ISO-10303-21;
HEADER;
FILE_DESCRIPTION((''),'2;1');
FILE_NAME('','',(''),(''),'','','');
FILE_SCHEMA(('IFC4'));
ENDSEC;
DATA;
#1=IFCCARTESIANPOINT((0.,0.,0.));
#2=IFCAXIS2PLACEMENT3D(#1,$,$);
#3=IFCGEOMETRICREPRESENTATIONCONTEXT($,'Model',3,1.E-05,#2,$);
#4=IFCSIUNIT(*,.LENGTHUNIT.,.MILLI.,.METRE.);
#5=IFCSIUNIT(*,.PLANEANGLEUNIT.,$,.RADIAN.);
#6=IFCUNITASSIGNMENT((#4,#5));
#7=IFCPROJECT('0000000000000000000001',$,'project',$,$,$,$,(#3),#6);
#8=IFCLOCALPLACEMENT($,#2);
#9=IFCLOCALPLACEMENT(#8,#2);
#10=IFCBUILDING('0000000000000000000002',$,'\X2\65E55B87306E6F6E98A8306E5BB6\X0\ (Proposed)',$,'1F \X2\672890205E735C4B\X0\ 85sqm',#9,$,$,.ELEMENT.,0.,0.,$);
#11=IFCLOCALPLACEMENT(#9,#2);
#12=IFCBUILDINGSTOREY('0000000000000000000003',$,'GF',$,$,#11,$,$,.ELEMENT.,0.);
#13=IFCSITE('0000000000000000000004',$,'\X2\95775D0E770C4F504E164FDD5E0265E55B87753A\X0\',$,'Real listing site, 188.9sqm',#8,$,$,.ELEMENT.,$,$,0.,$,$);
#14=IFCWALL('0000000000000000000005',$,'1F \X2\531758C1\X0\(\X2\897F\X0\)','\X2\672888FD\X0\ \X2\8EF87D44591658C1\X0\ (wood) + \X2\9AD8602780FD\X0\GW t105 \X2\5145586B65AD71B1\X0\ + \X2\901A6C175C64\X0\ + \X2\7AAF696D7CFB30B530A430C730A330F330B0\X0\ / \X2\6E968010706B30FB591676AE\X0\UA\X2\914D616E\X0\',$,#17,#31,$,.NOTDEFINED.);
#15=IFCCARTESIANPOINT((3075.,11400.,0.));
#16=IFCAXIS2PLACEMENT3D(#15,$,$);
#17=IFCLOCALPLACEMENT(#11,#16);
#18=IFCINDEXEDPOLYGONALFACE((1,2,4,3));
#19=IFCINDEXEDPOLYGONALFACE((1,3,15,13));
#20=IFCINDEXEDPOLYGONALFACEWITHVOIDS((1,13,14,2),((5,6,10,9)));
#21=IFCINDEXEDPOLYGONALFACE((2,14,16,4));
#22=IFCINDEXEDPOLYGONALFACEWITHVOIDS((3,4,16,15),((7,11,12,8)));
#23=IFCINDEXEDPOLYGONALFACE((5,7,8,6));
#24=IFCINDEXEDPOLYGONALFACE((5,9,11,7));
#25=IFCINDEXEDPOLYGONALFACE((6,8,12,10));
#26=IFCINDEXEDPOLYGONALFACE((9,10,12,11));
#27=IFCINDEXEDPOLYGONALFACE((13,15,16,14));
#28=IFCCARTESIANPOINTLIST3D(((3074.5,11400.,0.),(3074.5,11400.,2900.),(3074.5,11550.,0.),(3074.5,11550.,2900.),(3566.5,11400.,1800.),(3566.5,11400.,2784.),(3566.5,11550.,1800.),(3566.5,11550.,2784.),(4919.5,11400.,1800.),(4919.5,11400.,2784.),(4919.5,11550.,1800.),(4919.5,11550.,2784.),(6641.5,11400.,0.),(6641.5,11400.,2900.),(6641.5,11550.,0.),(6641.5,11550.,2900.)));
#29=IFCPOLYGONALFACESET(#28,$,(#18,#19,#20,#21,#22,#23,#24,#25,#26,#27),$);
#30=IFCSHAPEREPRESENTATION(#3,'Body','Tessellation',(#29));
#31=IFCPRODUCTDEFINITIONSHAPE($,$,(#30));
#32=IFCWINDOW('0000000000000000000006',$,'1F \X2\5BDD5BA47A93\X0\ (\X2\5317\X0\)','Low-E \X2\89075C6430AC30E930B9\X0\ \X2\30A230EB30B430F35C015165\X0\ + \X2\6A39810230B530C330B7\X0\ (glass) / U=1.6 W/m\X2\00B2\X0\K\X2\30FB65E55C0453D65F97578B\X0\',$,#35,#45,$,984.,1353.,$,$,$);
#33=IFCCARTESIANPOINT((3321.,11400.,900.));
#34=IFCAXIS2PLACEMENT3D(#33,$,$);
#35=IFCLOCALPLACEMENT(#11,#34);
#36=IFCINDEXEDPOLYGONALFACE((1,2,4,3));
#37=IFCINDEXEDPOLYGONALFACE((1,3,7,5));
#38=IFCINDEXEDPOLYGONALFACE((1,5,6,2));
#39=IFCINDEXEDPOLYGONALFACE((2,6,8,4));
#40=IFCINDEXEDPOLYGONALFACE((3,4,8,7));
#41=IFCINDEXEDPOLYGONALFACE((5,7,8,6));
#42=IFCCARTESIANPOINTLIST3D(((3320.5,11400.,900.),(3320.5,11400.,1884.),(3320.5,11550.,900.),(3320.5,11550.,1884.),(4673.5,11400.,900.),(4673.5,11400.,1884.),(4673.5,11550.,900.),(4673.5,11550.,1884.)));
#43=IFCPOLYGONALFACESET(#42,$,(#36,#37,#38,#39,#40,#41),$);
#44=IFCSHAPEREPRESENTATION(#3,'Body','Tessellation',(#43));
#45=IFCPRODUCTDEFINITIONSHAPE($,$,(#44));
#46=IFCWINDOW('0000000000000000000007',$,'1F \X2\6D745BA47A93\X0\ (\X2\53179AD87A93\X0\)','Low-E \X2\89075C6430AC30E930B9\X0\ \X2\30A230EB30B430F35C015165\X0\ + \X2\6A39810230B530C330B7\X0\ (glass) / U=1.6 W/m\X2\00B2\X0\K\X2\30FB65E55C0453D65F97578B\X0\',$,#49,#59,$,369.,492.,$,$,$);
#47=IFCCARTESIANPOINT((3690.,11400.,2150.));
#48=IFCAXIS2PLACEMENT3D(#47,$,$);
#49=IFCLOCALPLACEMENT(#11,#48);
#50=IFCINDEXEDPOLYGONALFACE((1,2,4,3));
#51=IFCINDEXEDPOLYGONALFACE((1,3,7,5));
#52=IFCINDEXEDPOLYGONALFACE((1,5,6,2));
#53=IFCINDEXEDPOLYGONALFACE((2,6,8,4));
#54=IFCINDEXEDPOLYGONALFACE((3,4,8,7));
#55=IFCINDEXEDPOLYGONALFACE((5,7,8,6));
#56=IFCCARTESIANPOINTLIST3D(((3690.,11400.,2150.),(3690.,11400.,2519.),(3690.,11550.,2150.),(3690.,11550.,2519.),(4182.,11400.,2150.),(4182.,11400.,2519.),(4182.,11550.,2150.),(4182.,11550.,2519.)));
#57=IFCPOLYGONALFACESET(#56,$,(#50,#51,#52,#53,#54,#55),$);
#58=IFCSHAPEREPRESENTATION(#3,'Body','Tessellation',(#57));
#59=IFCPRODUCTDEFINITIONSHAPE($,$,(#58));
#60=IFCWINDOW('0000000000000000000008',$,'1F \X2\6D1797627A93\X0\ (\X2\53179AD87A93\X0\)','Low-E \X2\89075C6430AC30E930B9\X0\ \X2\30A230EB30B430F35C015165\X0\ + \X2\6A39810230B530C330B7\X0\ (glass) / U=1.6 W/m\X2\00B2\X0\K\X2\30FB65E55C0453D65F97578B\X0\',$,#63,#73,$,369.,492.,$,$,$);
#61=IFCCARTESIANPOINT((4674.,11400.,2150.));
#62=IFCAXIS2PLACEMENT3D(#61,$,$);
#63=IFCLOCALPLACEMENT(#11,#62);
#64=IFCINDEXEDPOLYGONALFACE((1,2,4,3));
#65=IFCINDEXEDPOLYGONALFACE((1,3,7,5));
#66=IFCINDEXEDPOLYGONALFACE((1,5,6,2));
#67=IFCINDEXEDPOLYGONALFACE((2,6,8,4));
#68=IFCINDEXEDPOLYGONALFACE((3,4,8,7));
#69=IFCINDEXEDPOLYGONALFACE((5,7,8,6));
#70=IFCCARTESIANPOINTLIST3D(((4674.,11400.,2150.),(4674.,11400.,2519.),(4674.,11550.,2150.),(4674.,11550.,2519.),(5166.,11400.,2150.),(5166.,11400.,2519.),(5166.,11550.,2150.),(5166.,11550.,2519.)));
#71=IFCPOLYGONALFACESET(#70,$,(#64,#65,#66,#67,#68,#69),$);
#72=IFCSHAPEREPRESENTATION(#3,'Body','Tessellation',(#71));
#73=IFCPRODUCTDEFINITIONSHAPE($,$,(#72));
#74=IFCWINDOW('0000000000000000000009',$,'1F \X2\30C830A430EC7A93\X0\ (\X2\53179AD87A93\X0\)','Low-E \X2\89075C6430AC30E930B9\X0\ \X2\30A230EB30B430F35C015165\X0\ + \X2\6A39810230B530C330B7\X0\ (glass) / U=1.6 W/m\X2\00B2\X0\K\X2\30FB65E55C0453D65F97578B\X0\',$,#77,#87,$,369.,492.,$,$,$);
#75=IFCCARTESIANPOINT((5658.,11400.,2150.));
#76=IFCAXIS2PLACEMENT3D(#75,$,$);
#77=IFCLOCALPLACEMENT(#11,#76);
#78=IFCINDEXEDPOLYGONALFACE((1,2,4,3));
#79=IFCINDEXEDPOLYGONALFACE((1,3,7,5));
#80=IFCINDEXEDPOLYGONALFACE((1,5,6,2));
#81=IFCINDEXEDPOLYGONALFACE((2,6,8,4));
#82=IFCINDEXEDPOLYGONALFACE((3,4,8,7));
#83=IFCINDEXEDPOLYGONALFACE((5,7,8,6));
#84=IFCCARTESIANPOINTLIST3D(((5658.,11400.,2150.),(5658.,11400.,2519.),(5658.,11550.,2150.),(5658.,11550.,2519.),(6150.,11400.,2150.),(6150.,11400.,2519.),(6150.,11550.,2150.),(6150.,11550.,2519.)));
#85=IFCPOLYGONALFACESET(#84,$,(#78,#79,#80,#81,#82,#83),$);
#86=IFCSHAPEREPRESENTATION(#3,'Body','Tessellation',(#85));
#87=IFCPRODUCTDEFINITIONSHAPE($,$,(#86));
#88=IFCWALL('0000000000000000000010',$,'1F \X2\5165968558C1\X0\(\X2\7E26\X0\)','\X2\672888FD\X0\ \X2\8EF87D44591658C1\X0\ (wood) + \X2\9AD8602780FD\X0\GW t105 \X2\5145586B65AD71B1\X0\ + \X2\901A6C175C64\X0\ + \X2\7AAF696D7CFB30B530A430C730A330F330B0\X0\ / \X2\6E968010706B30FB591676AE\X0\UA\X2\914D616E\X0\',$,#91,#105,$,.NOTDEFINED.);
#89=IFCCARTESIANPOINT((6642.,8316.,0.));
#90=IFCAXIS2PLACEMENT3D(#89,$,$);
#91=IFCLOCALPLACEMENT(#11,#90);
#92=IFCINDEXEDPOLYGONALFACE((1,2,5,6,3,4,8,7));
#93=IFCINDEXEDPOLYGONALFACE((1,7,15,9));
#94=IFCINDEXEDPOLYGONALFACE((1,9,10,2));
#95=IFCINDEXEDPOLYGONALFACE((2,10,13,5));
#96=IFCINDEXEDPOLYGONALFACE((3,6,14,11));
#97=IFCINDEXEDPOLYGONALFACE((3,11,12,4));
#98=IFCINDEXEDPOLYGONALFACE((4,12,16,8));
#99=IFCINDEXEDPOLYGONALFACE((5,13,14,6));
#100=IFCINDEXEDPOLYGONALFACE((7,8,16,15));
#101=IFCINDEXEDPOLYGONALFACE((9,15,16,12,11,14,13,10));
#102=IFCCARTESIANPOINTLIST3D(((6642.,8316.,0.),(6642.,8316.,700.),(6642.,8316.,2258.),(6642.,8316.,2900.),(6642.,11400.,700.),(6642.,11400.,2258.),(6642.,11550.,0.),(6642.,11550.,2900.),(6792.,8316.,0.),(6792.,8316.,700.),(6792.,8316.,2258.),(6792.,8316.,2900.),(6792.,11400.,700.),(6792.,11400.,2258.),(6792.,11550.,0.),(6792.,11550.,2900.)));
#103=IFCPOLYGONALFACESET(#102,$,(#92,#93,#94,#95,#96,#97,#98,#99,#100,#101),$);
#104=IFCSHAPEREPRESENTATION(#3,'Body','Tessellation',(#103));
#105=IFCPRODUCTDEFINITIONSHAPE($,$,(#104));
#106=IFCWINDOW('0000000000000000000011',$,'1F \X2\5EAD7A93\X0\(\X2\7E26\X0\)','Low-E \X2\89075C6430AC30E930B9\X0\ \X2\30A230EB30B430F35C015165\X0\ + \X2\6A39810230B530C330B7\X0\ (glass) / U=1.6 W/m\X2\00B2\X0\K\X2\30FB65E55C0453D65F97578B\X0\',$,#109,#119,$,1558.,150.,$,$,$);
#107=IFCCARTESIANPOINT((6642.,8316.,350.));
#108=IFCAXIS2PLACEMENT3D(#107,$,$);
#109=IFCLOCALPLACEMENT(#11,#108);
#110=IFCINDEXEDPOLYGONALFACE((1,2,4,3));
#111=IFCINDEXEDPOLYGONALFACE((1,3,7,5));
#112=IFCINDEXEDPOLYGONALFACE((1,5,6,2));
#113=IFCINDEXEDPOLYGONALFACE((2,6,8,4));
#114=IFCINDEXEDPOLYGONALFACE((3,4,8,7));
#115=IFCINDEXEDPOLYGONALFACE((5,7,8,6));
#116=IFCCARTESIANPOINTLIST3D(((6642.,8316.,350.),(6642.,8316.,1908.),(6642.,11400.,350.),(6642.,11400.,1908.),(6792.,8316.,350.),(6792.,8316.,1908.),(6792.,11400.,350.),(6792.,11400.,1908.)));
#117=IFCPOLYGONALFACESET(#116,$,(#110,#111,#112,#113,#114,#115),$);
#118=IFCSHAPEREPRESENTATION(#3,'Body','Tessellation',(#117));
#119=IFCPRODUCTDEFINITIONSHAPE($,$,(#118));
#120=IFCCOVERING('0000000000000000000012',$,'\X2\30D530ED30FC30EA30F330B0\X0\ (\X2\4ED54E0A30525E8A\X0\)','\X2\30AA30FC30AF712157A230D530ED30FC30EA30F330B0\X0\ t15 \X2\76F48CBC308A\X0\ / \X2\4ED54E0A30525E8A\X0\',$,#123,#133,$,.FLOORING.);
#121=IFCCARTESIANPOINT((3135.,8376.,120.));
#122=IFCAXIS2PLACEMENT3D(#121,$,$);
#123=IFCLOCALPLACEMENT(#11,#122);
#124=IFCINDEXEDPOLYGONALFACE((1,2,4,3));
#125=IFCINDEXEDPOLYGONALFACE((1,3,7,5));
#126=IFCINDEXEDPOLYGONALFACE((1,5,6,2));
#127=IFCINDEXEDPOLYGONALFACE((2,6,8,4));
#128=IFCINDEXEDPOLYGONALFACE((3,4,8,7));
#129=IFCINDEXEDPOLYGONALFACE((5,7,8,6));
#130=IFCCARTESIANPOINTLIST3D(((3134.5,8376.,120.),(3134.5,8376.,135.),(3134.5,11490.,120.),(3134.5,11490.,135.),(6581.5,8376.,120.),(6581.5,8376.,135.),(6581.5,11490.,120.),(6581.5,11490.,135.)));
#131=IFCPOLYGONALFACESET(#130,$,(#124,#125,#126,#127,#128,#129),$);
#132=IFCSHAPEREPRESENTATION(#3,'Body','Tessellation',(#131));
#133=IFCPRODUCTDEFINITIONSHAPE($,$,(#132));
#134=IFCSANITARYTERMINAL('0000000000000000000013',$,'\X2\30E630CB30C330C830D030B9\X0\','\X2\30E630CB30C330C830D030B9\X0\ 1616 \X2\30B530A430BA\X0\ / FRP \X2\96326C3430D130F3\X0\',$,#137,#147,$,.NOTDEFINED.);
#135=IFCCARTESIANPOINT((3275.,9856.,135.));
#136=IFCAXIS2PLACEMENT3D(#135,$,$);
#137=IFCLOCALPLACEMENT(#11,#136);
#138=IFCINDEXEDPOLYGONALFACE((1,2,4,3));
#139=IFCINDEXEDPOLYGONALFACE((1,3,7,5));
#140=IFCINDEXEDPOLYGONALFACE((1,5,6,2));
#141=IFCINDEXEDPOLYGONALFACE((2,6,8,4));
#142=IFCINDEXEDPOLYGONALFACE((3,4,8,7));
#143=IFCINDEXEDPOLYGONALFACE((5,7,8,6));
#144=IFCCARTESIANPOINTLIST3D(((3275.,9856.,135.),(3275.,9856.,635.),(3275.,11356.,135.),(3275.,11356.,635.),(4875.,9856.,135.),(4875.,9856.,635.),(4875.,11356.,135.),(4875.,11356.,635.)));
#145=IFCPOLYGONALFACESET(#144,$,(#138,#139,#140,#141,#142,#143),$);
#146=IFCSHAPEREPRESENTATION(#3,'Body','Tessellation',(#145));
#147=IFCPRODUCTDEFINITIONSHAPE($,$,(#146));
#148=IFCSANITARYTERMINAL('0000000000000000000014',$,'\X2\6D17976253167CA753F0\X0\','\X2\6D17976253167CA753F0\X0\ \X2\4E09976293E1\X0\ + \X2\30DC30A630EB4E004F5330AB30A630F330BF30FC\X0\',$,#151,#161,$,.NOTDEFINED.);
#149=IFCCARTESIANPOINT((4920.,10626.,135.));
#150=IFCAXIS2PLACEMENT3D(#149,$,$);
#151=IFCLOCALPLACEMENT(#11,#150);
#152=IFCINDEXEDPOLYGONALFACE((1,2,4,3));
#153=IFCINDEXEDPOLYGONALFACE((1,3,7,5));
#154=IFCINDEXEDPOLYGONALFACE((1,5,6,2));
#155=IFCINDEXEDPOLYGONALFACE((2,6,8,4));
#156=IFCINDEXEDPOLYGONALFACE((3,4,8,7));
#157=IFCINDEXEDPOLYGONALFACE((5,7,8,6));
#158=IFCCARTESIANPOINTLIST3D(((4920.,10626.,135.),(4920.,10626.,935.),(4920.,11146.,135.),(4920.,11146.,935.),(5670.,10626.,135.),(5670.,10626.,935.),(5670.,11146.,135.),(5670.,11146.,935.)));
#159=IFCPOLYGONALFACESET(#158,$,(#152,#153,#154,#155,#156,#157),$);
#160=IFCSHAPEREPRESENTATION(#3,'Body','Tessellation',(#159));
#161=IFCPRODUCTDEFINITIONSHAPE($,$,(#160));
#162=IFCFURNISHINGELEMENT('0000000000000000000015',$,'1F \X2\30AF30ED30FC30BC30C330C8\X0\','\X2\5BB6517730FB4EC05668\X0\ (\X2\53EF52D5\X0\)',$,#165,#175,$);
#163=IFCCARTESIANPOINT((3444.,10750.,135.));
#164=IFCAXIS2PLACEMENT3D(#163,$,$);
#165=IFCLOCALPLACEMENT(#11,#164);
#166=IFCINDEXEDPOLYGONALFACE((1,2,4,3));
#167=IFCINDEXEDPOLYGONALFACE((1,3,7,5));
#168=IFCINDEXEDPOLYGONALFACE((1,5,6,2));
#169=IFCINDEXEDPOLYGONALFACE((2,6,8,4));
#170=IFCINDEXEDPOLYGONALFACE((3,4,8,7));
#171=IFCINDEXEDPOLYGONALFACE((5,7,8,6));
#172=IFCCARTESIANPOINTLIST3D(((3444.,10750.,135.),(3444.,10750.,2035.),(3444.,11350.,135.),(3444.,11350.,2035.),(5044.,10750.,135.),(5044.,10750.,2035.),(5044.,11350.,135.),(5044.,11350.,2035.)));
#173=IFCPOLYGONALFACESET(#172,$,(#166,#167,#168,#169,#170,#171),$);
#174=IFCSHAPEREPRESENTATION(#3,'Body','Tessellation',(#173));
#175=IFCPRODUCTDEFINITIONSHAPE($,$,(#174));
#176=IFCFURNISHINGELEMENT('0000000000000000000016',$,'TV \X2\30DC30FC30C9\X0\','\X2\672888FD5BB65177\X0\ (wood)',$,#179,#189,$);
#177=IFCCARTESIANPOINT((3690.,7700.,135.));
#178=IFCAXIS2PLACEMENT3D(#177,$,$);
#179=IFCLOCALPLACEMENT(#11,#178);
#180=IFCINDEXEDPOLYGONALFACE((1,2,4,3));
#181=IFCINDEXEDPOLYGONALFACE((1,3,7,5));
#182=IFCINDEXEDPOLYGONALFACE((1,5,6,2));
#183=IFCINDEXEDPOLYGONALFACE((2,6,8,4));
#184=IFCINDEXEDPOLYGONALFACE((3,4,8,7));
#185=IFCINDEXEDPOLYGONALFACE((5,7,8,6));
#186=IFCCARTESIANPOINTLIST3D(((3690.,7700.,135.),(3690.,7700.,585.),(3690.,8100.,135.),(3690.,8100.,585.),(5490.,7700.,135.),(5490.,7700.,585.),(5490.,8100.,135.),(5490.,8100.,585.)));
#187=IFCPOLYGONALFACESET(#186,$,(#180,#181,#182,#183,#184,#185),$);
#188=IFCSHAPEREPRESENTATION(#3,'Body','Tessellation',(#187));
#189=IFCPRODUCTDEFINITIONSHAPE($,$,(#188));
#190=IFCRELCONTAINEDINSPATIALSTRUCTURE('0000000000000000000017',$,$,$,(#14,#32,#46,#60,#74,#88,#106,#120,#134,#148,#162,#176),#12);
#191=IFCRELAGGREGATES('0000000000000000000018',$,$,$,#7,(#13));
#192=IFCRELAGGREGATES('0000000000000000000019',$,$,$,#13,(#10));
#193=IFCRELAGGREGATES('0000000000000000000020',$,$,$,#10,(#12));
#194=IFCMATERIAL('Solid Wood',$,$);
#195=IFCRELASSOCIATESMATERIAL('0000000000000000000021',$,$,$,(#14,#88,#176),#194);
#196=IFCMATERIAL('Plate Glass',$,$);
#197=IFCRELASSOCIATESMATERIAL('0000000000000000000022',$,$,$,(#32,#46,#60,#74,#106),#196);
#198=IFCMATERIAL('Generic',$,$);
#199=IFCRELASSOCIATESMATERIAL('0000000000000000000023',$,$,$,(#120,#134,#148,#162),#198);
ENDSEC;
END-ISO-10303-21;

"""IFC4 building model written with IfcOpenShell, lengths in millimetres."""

from ifc_helpers import new_model, si_unit, frame, frame_2d, origin, place, context, project, spatial, rectangle, extrude, material, element, fill, save


model = new_model("IFC4")

# Units and contexts
model_context = context("Model", 3, precision=1e-05, world=origin())
ifc_project = project(units=[si_unit("LENGTHUNIT", "METRE", prefix="MILLI"), si_unit("PLANEANGLEUNIT", "RADIAN")], contexts=[model_context])

# Site, building, storey
site_placement = place(None, origin())
site = spatial("IfcSite", under=ifc_project, at=site_placement, Name="長崎県佐世保市日宇町", ObjectType="Real listing site, 188.9sqm", CompositionType="ELEMENT", RefElevation=0.0)
building_placement = place(site_placement, origin())
building = spatial("IfcBuilding", under=site, at=building_placement, Name="日宇の潮風の家 (Proposed)", ObjectType="1F 木造平屋 85sqm", CompositionType="ELEMENT", ElevationOfRefHeight=0.0, ElevationOfTerrain=0.0)
storey_placement = place(building_placement, origin())
storey = spatial("IfcBuildingStorey", under=building, at=storey_placement, Name="GF", CompositionType="ELEMENT", Elevation=0.0)

# Shared definitions
ifc_material_1 = material(Name="Solid Wood")

# Wall, openings, windows
wall_1_placement = place(storey_placement, frame((3075.0, 11400.0, 0.0)))
wall_1 = element("IfcWall", 1, at=wall_1_placement, inside=storey, material=ifc_material_1, Name="1F 北壁(西)", Description="木製 軸組外壁 (wood) + 高性能GW t105 充填断熱 + 通気層 + 窯業系サイディング / 準耐火・外皮UA配慮", PredefinedType="NOTDEFINED", context=model_context, shape_type="SweptSolid", body=[
    extrude(rectangle(XDim=3567.0, YDim=150.0, at=frame_2d((1783.0, 75.0))), frame((3075.0, 11400.0, 0.0)), (0.0, 0.0, 1.0), 2900.0),
])
opening_1_placement = place(storey_placement, frame((3321.0, 11400.0, 900.0)))
opening_1 = element("IfcOpeningElement", 2, at=opening_1_placement, cuts=wall_1, PredefinedType="NOTDEFINED", context=model_context, shape_type="SweptSolid", body=[
    extrude(rectangle(XDim=1353.0, YDim=150.0, at=frame_2d((676.0, 75.0))), frame((3321.0, 11400.0, 900.0)), (0.0, 0.0, 1.0), 984.0),
])
opening_2_placement = place(storey_placement, frame((3690.0, 11400.0, 2150.0)))
opening_2 = element("IfcOpeningElement", 3, at=opening_2_placement, cuts=wall_1, PredefinedType="NOTDEFINED", context=model_context, shape_type="SweptSolid", body=[
    extrude(rectangle(XDim=492.0, YDim=150.0, at=frame_2d((246.0, 75.0))), frame((3690.0, 11400.0, 2150.0)), (0.0, 0.0, 1.0), 369.0),
])
opening_3_placement = place(storey_placement, frame((4674.0, 11400.0, 2150.0)))
opening_3 = element("IfcOpeningElement", 4, at=opening_3_placement, cuts=wall_1, PredefinedType="NOTDEFINED", context=model_context, shape_type="SweptSolid", body=[
    extrude(rectangle(XDim=492.0, YDim=150.0, at=frame_2d((246.0, 75.0))), frame((4674.0, 11400.0, 2150.0)), (0.0, 0.0, 1.0), 369.0),
])
opening_4_placement = place(storey_placement, frame((5658.0, 11400.0, 2150.0)))
opening_4 = element("IfcOpeningElement", 5, at=opening_4_placement, cuts=wall_1, PredefinedType="NOTDEFINED", context=model_context, shape_type="SweptSolid", body=[
    extrude(rectangle(XDim=492.0, YDim=150.0, at=frame_2d((246.0, 75.0))), frame((5658.0, 11400.0, 2150.0)), (0.0, 0.0, 1.0), 369.0),
])
ifc_material_2 = material(Name="Plate Glass")
window_1_placement = place(storey_placement, frame((3321.0, 11400.0, 900.0)))
window_1 = element("IfcWindow", 6, at=window_1_placement, inside=storey, material=ifc_material_2, Name="1F 寝室窓 (北)", Description="Low-E 複層ガラス アルゴン封入 + 樹脂サッシ (glass) / U=1.6 W/m²K・日射取得型", OverallHeight=984.0, OverallWidth=1353.0, context=model_context, shape_type="SweptSolid", body=[
    extrude(rectangle(XDim=1353.0, YDim=150.0, at=frame_2d((676.0, 75.0))), frame((3321.0, 11400.0, 900.0)), (0.0, 0.0, 1.0), 984.0),
])
fill(opening_1, window_1)
window_2_placement = place(storey_placement, frame((3690.0, 11400.0, 2150.0)))
window_2 = element("IfcWindow", 7, at=window_2_placement, inside=storey, material=ifc_material_2, Name="1F 浴室窓 (北高窓)", Description="Low-E 複層ガラス アルゴン封入 + 樹脂サッシ (glass) / U=1.6 W/m²K・日射取得型", OverallHeight=369.0, OverallWidth=492.0, context=model_context, shape_type="SweptSolid", body=[
    extrude(rectangle(XDim=492.0, YDim=150.0, at=frame_2d((246.0, 75.0))), frame((3690.0, 11400.0, 2150.0)), (0.0, 0.0, 1.0), 369.0),
])
fill(opening_2, window_2)
window_3_placement = place(storey_placement, frame((4674.0, 11400.0, 2150.0)))
window_3 = element("IfcWindow", 8, at=window_3_placement, inside=storey, material=ifc_material_2, Name="1F 洗面窓 (北高窓)", Description="Low-E 複層ガラス アルゴン封入 + 樹脂サッシ (glass) / U=1.6 W/m²K・日射取得型", OverallHeight=369.0, OverallWidth=492.0, context=model_context, shape_type="SweptSolid", body=[
    extrude(rectangle(XDim=492.0, YDim=150.0, at=frame_2d((246.0, 75.0))), frame((4674.0, 11400.0, 2150.0)), (0.0, 0.0, 1.0), 369.0),
])
fill(opening_3, window_3)
window_4_placement = place(storey_placement, frame((5658.0, 11400.0, 2150.0)))
window_4 = element("IfcWindow", 9, at=window_4_placement, inside=storey, material=ifc_material_2, Name="1F トイレ窓 (北高窓)", Description="Low-E 複層ガラス アルゴン封入 + 樹脂サッシ (glass) / U=1.6 W/m²K・日射取得型", OverallHeight=369.0, OverallWidth=492.0, context=model_context, shape_type="SweptSolid", body=[
    extrude(rectangle(XDim=492.0, YDim=150.0, at=frame_2d((246.0, 75.0))), frame((5658.0, 11400.0, 2150.0)), (0.0, 0.0, 1.0), 369.0),
])
fill(opening_4, window_4)

# Wall, opening, window
wall_2_placement = place(storey_placement, frame((6642.0, 8316.0, 0.0)))
wall_2 = element("IfcWall", 10, at=wall_2_placement, inside=storey, material=ifc_material_1, Name="1F 入隅壁(縦)", Description="木製 軸組外壁 (wood) + 高性能GW t105 充填断熱 + 通気層 + 窯業系サイディング / 準耐火・外皮UA配慮", PredefinedType="NOTDEFINED", context=model_context, shape_type="SweptSolid", body=[
    extrude(rectangle(XDim=150.0, YDim=3234.0, at=frame_2d((75.0, 1617.0))), frame((6642.0, 8316.0, 0.0)), (0.0, 0.0, 1.0), 2900.0),
])
opening_5_placement = place(storey_placement, frame((6642.0, 8316.0, 350.0)))
opening_5 = element("IfcOpeningElement", 11, at=opening_5_placement, cuts=wall_2, PredefinedType="NOTDEFINED", context=model_context, shape_type="SweptSolid", body=[
    extrude(rectangle(XDim=150.0, YDim=3084.0, at=frame_2d((75.0, 1542.0))), frame((6642.0, 8316.0, 350.0)), (0.0, 0.0, 1.0), 1558.0),
])
window_5_placement = place(storey_placement, frame((6642.0, 8316.0, 350.0)))
window_5 = element("IfcWindow", 12, at=window_5_placement, inside=storey, material=ifc_material_2, Name="1F 庭窓(縦)", Description="Low-E 複層ガラス アルゴン封入 + 樹脂サッシ (glass) / U=1.6 W/m²K・日射取得型", OverallHeight=1558.0, OverallWidth=150.0, context=model_context, shape_type="SweptSolid", body=[
    extrude(rectangle(XDim=150.0, YDim=3084.0, at=frame_2d((75.0, 1542.0))), frame((6642.0, 8316.0, 350.0)), (0.0, 0.0, 1.0), 1558.0),
])
fill(opening_5, window_5)

# Covering
ifc_material_3 = material(Name="Generic")
covering_placement = place(storey_placement, frame((3135.0, 8376.0, 120.0)))
element("IfcCovering", 13, at=covering_placement, inside=storey, material=ifc_material_3, Name="フローリング (仕上げ床)", Description="オーク無垢フローリング t15 直貼り / 仕上げ床", PredefinedType="FLOORING", context=model_context, shape_type="SweptSolid", body=[
    extrude(rectangle(XDim=3447.0, YDim=3114.0, at=frame_2d((1723.0, 1557.0))), frame((3135.0, 8376.0, 120.0)), (0.0, 0.0, 1.0), 15.0),
])

# Sanitary terminals
sanitary_terminal_1_placement = place(storey_placement, frame((3275.0, 9856.0, 135.0)))
element("IfcSanitaryTerminal", 14, at=sanitary_terminal_1_placement, inside=storey, material=ifc_material_3, Name="ユニットバス", Description="ユニットバス 1616 サイズ / FRP 防水パン", PredefinedType="NOTDEFINED", context=model_context, shape_type="SweptSolid", body=[
    extrude(rectangle(XDim=1600.0, YDim=1500.0, at=frame_2d((800.0, 750.0))), frame((3275.0, 9856.0, 135.0)), (0.0, 0.0, 1.0), 500.0),
])
sanitary_terminal_2_placement = place(storey_placement, frame((4920.0, 10626.0, 135.0)))
element("IfcSanitaryTerminal", 15, at=sanitary_terminal_2_placement, inside=storey, material=ifc_material_3, Name="洗面化粧台", Description="洗面化粧台 三面鏡 + ボウル一体カウンター", PredefinedType="NOTDEFINED", context=model_context, shape_type="SweptSolid", body=[
    extrude(rectangle(XDim=750.0, YDim=520.0, at=frame_2d((375.0, 260.0))), frame((4920.0, 10626.0, 135.0)), (0.0, 0.0, 1.0), 800.0),
])

# Furnishing elements
furnishing_1_placement = place(storey_placement, frame((3444.0, 10750.0, 135.0)))
element("IfcFurnishingElement", 16, at=furnishing_1_placement, inside=storey, material=ifc_material_3, Name="1F クローゼット", Description="家具・什器 (可動)", context=model_context, shape_type="SweptSolid", body=[
    extrude(rectangle(XDim=1600.0, YDim=600.0, at=frame_2d((800.0, 300.0))), frame((3444.0, 10750.0, 135.0)), (0.0, 0.0, 1.0), 1900.0),
])
furnishing_2_placement = place(storey_placement, frame((3690.0, 7700.0, 135.0)))
element("IfcFurnishingElement", 17, at=furnishing_2_placement, inside=storey, material=ifc_material_1, Name="TV ボード", Description="木製家具 (wood)", context=model_context, shape_type="SweptSolid", body=[
    extrude(rectangle(XDim=1800.0, YDim=400.0, at=frame_2d((900.0, 200.0))), frame((3690.0, 7700.0, 135.0)), (0.0, 0.0, 1.0), 450.0),
])

save(model, "model.ifc")
